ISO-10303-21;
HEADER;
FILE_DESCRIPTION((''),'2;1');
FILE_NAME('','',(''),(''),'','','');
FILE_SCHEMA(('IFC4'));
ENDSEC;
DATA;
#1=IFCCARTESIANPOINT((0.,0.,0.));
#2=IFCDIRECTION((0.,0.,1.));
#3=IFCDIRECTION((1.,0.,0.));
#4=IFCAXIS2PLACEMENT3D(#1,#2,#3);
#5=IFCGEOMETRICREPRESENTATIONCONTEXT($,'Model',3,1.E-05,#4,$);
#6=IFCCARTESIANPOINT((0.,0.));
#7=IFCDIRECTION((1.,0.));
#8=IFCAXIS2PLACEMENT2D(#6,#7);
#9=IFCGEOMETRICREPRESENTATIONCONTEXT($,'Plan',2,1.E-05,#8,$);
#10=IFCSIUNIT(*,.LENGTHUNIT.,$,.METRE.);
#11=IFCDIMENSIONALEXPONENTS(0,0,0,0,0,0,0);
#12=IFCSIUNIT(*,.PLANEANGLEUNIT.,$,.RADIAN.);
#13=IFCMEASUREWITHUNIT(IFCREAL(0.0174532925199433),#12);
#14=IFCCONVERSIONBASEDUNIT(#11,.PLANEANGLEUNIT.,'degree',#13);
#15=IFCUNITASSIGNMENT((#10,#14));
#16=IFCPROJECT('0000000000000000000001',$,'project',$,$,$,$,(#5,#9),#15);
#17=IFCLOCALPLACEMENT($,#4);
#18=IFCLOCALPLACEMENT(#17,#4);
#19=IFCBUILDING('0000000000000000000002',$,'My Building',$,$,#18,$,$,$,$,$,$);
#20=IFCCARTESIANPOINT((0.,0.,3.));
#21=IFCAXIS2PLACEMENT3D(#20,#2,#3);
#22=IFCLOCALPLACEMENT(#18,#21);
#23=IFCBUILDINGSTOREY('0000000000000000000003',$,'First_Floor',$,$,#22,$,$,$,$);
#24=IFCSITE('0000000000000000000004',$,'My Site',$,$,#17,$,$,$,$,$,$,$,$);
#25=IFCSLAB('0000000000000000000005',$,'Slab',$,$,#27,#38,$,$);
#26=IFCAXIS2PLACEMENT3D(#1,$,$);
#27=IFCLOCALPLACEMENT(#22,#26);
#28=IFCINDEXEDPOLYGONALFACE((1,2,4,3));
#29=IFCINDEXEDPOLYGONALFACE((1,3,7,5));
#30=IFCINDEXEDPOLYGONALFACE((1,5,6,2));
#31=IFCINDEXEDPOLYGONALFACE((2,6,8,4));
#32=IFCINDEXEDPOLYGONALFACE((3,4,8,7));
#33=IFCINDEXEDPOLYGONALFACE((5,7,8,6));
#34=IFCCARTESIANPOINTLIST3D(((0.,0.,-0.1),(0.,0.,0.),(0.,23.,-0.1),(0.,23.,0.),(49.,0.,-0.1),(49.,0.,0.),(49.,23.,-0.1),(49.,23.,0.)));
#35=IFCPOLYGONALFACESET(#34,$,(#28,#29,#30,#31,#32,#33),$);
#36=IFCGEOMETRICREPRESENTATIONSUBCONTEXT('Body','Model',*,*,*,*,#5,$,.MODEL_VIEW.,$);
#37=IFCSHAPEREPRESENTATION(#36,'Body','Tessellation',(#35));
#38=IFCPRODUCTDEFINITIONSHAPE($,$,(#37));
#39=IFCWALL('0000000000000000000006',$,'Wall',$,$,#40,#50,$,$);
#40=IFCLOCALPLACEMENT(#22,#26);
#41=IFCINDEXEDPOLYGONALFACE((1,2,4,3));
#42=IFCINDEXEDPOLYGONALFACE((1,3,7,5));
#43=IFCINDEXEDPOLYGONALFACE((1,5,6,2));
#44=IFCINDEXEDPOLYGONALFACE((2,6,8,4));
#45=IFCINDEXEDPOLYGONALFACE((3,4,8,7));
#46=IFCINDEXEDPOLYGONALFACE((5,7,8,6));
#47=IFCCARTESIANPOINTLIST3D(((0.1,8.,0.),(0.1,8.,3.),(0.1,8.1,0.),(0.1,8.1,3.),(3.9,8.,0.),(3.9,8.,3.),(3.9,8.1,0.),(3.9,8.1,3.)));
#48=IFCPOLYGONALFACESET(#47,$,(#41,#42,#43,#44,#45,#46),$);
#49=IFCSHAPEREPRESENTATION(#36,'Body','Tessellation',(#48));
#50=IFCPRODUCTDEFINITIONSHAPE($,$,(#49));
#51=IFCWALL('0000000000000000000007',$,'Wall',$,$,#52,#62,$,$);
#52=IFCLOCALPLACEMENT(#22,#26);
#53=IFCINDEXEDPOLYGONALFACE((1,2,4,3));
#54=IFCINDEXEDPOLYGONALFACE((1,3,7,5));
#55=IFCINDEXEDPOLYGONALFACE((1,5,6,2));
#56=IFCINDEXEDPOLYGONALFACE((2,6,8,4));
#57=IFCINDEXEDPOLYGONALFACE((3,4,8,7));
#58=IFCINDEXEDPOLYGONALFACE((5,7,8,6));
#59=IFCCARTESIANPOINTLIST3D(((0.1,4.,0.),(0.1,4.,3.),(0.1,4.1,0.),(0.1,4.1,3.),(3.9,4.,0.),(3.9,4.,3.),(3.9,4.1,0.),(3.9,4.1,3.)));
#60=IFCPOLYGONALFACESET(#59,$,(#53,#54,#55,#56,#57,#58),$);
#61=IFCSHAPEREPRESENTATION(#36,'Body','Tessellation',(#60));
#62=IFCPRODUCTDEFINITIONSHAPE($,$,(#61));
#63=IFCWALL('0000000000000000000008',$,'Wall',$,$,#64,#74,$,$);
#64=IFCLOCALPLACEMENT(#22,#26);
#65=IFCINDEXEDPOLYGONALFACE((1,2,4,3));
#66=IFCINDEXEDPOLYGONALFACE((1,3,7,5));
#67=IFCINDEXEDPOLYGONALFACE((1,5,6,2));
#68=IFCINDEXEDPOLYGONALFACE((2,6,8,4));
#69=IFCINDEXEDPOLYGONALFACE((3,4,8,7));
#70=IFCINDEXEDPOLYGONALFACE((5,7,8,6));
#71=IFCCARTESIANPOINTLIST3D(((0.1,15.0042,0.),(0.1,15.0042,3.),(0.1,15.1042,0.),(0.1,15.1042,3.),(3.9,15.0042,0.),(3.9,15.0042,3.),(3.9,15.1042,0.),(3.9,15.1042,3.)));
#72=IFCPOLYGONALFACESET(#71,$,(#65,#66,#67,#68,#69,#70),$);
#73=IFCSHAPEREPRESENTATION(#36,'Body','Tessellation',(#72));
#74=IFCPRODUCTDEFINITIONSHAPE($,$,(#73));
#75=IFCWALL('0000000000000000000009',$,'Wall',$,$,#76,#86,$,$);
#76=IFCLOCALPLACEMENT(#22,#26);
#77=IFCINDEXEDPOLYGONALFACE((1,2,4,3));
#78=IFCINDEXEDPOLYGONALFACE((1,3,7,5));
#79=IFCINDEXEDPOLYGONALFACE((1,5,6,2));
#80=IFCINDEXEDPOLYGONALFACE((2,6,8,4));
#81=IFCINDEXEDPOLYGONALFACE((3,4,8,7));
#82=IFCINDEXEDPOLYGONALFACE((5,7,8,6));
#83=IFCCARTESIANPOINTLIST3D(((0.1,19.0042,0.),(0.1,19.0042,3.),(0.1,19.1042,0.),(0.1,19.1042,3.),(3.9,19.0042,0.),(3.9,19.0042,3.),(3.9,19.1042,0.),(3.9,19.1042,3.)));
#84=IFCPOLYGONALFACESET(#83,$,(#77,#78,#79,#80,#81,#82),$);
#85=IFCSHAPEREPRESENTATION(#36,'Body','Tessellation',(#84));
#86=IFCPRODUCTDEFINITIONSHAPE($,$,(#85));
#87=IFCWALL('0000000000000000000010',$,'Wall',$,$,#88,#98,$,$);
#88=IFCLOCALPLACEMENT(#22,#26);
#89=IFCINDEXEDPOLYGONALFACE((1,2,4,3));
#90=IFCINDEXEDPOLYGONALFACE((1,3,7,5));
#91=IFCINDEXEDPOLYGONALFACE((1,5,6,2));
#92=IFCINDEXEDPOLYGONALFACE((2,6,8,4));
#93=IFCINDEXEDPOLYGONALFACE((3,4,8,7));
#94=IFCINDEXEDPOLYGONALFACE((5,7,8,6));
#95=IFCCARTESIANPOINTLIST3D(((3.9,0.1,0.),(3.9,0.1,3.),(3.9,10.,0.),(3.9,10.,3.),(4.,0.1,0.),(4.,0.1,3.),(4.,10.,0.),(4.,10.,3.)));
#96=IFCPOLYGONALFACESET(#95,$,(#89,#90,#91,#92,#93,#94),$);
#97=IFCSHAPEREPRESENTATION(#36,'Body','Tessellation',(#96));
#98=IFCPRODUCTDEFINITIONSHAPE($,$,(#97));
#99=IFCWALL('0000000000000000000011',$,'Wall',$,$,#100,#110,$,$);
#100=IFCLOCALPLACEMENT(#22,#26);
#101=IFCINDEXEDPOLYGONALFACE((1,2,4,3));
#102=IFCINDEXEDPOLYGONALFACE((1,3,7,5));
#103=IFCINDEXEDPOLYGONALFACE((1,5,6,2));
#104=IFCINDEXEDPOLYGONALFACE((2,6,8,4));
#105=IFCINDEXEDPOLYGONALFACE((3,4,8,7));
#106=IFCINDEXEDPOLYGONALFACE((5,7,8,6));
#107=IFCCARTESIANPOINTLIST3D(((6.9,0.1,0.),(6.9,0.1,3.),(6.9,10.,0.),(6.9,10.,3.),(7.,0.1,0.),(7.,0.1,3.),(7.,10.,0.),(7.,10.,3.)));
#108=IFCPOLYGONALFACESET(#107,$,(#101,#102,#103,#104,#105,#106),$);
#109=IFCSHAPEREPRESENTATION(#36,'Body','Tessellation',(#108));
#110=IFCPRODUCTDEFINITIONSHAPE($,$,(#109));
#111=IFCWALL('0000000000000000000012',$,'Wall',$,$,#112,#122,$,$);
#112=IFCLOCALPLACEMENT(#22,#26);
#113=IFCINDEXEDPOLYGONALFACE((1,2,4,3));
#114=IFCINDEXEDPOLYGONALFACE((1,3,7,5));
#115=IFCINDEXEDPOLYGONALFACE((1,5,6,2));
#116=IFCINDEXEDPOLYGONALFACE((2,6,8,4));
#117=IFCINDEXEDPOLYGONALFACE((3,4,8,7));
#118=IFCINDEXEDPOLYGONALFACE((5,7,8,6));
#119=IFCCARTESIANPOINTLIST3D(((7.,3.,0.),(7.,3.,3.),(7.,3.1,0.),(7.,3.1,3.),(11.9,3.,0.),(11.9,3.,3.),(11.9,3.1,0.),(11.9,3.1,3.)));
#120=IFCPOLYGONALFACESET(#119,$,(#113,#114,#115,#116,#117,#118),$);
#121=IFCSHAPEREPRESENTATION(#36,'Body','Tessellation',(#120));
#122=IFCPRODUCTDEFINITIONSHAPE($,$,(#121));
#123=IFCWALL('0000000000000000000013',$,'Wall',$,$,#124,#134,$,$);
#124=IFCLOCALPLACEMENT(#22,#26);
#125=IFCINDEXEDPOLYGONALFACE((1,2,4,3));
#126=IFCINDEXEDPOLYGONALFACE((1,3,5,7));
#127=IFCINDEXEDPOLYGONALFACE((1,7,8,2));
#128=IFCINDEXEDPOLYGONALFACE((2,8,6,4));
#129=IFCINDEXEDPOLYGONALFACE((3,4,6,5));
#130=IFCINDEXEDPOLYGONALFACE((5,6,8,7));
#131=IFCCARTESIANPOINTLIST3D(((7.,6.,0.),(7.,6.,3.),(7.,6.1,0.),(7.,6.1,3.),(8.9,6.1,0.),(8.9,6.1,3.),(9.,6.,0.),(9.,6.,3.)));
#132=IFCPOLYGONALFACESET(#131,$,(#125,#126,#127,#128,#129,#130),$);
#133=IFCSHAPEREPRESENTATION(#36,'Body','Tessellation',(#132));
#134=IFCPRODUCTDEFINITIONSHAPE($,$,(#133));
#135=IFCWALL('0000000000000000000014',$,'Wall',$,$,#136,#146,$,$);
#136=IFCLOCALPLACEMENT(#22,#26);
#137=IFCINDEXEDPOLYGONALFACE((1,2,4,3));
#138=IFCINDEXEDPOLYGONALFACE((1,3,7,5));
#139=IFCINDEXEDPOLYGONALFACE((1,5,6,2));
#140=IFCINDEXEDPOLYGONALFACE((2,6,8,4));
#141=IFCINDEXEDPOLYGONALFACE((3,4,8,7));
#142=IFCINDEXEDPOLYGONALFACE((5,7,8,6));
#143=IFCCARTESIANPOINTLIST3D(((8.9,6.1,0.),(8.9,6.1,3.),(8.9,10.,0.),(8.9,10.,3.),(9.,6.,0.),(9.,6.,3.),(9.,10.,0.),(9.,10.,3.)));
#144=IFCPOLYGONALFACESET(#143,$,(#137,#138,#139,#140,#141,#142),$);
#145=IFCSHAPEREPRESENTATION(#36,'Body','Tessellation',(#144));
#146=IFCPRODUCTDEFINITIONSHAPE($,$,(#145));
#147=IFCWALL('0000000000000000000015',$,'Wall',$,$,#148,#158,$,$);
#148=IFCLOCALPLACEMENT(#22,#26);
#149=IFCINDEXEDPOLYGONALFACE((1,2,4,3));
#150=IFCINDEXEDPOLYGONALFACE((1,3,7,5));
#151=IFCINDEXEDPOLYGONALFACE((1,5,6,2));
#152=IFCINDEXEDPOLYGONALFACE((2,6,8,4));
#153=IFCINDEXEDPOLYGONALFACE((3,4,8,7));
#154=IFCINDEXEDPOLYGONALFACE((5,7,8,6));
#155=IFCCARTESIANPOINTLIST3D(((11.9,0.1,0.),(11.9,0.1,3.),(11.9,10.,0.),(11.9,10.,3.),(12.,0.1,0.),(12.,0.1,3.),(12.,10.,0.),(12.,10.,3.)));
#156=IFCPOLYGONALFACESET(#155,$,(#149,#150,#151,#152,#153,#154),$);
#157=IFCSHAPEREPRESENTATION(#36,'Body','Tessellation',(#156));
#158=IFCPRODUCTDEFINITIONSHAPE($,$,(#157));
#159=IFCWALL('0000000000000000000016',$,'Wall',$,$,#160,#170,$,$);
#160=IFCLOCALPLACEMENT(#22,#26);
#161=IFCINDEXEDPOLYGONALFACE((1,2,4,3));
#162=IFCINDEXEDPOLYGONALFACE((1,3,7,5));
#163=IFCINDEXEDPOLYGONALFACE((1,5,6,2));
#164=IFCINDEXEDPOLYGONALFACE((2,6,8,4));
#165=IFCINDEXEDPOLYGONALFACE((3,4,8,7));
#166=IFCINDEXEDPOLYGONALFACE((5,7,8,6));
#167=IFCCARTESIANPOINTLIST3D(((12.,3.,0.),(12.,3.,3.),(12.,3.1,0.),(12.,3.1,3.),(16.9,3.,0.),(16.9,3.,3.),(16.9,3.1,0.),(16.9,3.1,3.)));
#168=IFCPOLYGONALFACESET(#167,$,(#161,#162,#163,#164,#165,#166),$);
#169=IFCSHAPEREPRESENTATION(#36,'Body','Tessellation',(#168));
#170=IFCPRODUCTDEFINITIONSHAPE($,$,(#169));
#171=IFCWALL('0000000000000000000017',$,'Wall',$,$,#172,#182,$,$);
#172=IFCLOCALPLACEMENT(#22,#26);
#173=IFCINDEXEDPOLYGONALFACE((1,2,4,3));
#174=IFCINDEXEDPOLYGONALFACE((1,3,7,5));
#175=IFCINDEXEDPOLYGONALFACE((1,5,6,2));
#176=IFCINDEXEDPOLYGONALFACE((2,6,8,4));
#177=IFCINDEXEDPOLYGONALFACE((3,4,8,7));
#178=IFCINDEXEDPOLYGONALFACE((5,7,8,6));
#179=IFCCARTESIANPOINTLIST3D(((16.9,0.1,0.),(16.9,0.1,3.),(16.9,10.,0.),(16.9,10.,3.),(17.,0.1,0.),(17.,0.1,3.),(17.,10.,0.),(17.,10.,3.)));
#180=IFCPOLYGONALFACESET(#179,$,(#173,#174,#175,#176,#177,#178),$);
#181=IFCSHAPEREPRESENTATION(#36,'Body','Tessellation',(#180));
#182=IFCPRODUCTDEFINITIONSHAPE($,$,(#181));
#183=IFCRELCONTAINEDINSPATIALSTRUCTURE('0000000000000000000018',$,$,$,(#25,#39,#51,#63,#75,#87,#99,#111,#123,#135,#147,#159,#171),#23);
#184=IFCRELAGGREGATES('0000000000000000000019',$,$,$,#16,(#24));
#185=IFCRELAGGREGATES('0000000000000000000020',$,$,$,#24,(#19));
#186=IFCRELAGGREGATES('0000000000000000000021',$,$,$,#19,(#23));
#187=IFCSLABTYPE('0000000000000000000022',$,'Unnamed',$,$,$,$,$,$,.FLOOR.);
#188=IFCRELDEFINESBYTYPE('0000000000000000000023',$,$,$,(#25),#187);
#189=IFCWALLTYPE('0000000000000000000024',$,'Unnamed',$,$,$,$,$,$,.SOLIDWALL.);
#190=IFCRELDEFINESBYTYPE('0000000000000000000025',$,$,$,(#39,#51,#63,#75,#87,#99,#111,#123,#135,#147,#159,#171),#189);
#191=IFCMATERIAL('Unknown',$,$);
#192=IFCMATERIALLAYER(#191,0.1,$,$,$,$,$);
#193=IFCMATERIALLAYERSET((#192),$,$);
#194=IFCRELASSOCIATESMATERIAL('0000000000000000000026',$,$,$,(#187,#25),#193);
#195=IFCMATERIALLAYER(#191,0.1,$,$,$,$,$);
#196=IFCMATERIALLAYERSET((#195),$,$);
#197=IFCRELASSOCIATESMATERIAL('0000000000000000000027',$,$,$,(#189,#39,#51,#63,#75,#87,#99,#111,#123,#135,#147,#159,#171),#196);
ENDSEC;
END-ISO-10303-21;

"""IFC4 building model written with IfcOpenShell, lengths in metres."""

from ifc_helpers import new_model, entity, si_unit, converted_unit, frame, origin_with_axes, origin_2d_with_axis, place, context, subcontext, project, spatial, line, indexed_curve, outline, extrude, material, layer, layer_set, layer_usage, type_object, element, save


model = new_model("IFC4")

# Units and contexts
model_context = context("Model", 3, precision=1e-05, world=origin_with_axes())
plan_context = context("Plan", 2, precision=1e-05, world=origin_2d_with_axis())
body_context = subcontext(model_context, "Body", "Model", "MODEL_VIEW")
ifc_project = project(units=[si_unit("LENGTHUNIT", "METRE"), converted_unit("PLANEANGLEUNIT", "degree", entity("IfcReal", 0.0174532925199433), si_unit("PLANEANGLEUNIT", "RADIAN"), dimensions=[0, 0, 0, 0, 0, 0, 0])], contexts=[model_context, plan_context])

# Site, building, storey
site_placement = place(None, origin_with_axes())
site = spatial("IfcSite", under=ifc_project, at=site_placement, Name="My Site")
building_placement = place(site_placement, origin_with_axes())
building = spatial("IfcBuilding", under=site, at=building_placement, Name="My Building")
storey_placement = place(building_placement, frame((0.0, 0.0, 3.0), z_axis=(0.0, 0.0, 1.0), x_axis=(1.0, 0.0, 0.0)))
storey = spatial("IfcBuildingStorey", under=building, at=storey_placement, Name="First_Floor")

# Slab
ifc_material = material(Name="Unknown")
ifc_layer_1 = layer(ifc_material, 0.1)
ifc_layer_set_1 = layer_set([ifc_layer_1])
ifc_layer_usage_1 = layer_usage(ifc_layer_set_1, "AXIS3", "POSITIVE", -0.1)
slab_type = type_object("IfcSlabType", Name="Unnamed", PredefinedType="FLOOR", material=ifc_layer_set_1)
slab_placement = place(storey_placement, frame((0.0, 23.0, 0.0), z_axis=(0.0, 0.0, 1.0), x_axis=(1.0, 0.0, 0.0)))
element("IfcSlab", 1, at=slab_placement, inside=storey, type_object=slab_type, material=ifc_layer_usage_1, Name="Slab", context=body_context, shape_type="SweptSolid", body=[
    extrude(outline(indexed_curve([(0.0, 0.0), (0.0, -23.0), (49.0, -23.0), (49.0, 0.0), (0.0, 0.0)])), frame((0.0, 0.0, -0.1), z_axis=(0.0, 0.0, 1.0), x_axis=(1.0, 0.0, 0.0)), (0.0, 0.0, 1.0), 0.1),
])

# Walls
ifc_layer_2 = layer(ifc_material, 0.1)
ifc_layer_set_2 = layer_set([ifc_layer_2])
ifc_layer_usage_2 = layer_usage(ifc_layer_set_2, "AXIS2", "POSITIVE", 0.0)
wall_type = type_object("IfcWallType", Name="Unnamed", PredefinedType="SOLIDWALL", material=ifc_layer_set_2)
wall_1_placement = place(storey_placement, frame((0.1, 8.0, 0.0), z_axis=(0.0, 0.0, 1.0), x_axis=(1.0, 0.0, 0.0)))
element("IfcWall", 2, at=wall_1_placement, inside=storey, type_object=wall_type, material=ifc_layer_usage_2, Name="Wall", context=body_context, shape_type="SweptSolid", body=[
    extrude(outline(indexed_curve([(0.0, 0.0), (0.0, 0.1), (3.8, 0.1), (3.8, 0.0)], segments=[line(1, 2, 3, 4, 1)])), origin_with_axes(), (0.0, 0.0, 1.0), 3.0),
])
ifc_layer_usage_3 = layer_usage(ifc_layer_set_2, "AXIS2", "POSITIVE", 0.0)
wall_2_placement = place(storey_placement, frame((0.1, 4.0, 0.0), z_axis=(0.0, 0.0, 1.0), x_axis=(1.0, 0.0, 0.0)))
element("IfcWall", 3, at=wall_2_placement, inside=storey, type_object=wall_type, material=ifc_layer_usage_3, Name="Wall", context=body_context, shape_type="SweptSolid", body=[
    extrude(outline(indexed_curve([(0.0, 0.0), (0.0, 0.1), (3.8, 0.1), (3.8, 0.0)], segments=[line(1, 2, 3, 4, 1)])), origin_with_axes(), (0.0, 0.0, 1.0), 3.0),
])
ifc_layer_usage_4 = layer_usage(ifc_layer_set_2, "AXIS2", "POSITIVE", 0.0)
wall_3_placement = place(storey_placement, frame((0.1, 15.0042, 0.0), z_axis=(0.0, 0.0, 1.0), x_axis=(1.0, 0.0, 0.0)))
element("IfcWall", 4, at=wall_3_placement, inside=storey, type_object=wall_type, material=ifc_layer_usage_4, Name="Wall", context=body_context, shape_type="SweptSolid", body=[
    extrude(outline(indexed_curve([(0.0, 0.0), (0.0, 0.1), (3.8, 0.1), (3.8, 0.0)], segments=[line(1, 2, 3, 4, 1)])), origin_with_axes(), (0.0, 0.0, 1.0), 3.0),
])
ifc_layer_usage_5 = layer_usage(ifc_layer_set_2, "AXIS2", "POSITIVE", 0.0)
wall_4_placement = place(storey_placement, frame((0.1, 19.0042, 0.0), z_axis=(0.0, 0.0, 1.0), x_axis=(1.0, 0.0, 0.0)))
element("IfcWall", 5, at=wall_4_placement, inside=storey, type_object=wall_type, material=ifc_layer_usage_5, Name="Wall", context=body_context, shape_type="SweptSolid", body=[
    extrude(outline(indexed_curve([(0.0, 0.0), (0.0, 0.1), (3.8, 0.1), (3.8, 0.0)], segments=[line(1, 2, 3, 4, 1)])), origin_with_axes(), (0.0, 0.0, 1.0), 3.0),
])
ifc_layer_usage_6 = layer_usage(ifc_layer_set_2, "AXIS2", "POSITIVE", 0.0)
wall_5_placement = place(storey_placement, frame((3.9, 10.0, 0.0), z_axis=(0.0, 0.0, 1.0), x_axis=(0.0, -1.0, 0.0)))
element("IfcWall", 6, at=wall_5_placement, inside=storey, type_object=wall_type, material=ifc_layer_usage_6, Name="Wall", context=body_context, shape_type="SweptSolid", body=[
    extrude(outline(indexed_curve([(0.0, 0.0), (0.0, 0.1), (9.9, 0.1), (9.9, 0.0)], segments=[line(1, 2, 3, 4, 1)])), origin_with_axes(), (0.0, 0.0, 1.0), 3.0),
])
ifc_layer_usage_7 = layer_usage(ifc_layer_set_2, "AXIS2", "POSITIVE", 0.0)
wall_6_placement = place(storey_placement, frame((6.9, 10.0, 0.0), z_axis=(0.0, 0.0, 1.0), x_axis=(0.0, -1.0, 0.0)))
element("IfcWall", 7, at=wall_6_placement, inside=storey, type_object=wall_type, material=ifc_layer_usage_7, Name="Wall", context=body_context, shape_type="SweptSolid", body=[
    extrude(outline(indexed_curve([(0.0, 0.0), (0.0, 0.1), (9.9, 0.1), (9.9, 0.0)], segments=[line(1, 2, 3, 4, 1)])), origin_with_axes(), (0.0, 0.0, 1.0), 3.0),
])
ifc_layer_usage_8 = layer_usage(ifc_layer_set_2, "AXIS2", "POSITIVE", 0.0)
wall_7_placement = place(storey_placement, frame((7.0, 3.0, 0.0), z_axis=(0.0, 0.0, 1.0), x_axis=(1.0, 0.0, 0.0)))
element("IfcWall", 8, at=wall_7_placement, inside=storey, type_object=wall_type, material=ifc_layer_usage_8, Name="Wall", context=body_context, shape_type="SweptSolid", body=[
    extrude(outline(indexed_curve([(0.0, 0.0), (0.0, 0.1), (4.9, 0.1), (4.9, 0.0)], segments=[line(1, 2, 3, 4, 1)])), origin_with_axes(), (0.0, 0.0, 1.0), 3.0),
])
ifc_layer_usage_9 = layer_usage(ifc_layer_set_2, "AXIS2", "POSITIVE", 0.0)
wall_8_placement = place(storey_placement, frame((7.0, 6.0, 0.0), z_axis=(0.0, 0.0, 1.0), x_axis=(1.0, 0.0, 0.0)))
element("IfcWall", 9, at=wall_8_placement, inside=storey, type_object=wall_type, material=ifc_layer_usage_9, Name="Wall", context=body_context, shape_type="SweptSolid", body=[
    extrude(outline(indexed_curve([(0.0, 0.0), (0.0, 0.1), (1.9, 0.1), (2.0, 0.0)], segments=[line(1, 2, 3, 4, 1)])), origin_with_axes(), (0.0, 0.0, 1.0), 3.0),
])
ifc_layer_usage_10 = layer_usage(ifc_layer_set_2, "AXIS2", "POSITIVE", 0.0)
wall_9_placement = place(storey_placement, frame((9.0, 6.0, 0.0), z_axis=(0.0, 0.0, 1.0), x_axis=(0.0, 1.0, 0.0)))
element("IfcWall", 10, at=wall_9_placement, inside=storey, type_object=wall_type, material=ifc_layer_usage_10, Name="Wall", context=body_context, shape_type="SweptSolid", body=[
    extrude(outline(indexed_curve([(0.0, 0.0), (0.1, 0.1), (4.0, 0.1), (4.0, 0.0)], segments=[line(1, 2, 3, 4, 1)])), origin_with_axes(), (0.0, 0.0, 1.0), 3.0),
])
ifc_layer_usage_11 = layer_usage(ifc_layer_set_2, "AXIS2", "POSITIVE", 0.0)
wall_10_placement = place(storey_placement, frame((11.9, 10.0, 0.0), z_axis=(0.0, 0.0, 1.0), x_axis=(0.0, -1.0, 0.0)))
element("IfcWall", 11, at=wall_10_placement, inside=storey, type_object=wall_type, material=ifc_layer_usage_11, Name="Wall", context=body_context, shape_type="SweptSolid", body=[
    extrude(outline(indexed_curve([(0.0, 0.0), (0.0, 0.1), (9.9, 0.1), (9.9, 0.0)], segments=[line(1, 2, 3, 4, 1)])), origin_with_axes(), (0.0, 0.0, 1.0), 3.0),
])
ifc_layer_usage_12 = layer_usage(ifc_layer_set_2, "AXIS2", "POSITIVE", 0.0)
wall_11_placement = place(storey_placement, frame((12.0, 3.0, 0.0), z_axis=(0.0, 0.0, 1.0), x_axis=(1.0, 0.0, 0.0)))
element("IfcWall", 12, at=wall_11_placement, inside=storey, type_object=wall_type, material=ifc_layer_usage_12, Name="Wall", context=body_context, shape_type="SweptSolid", body=[
    extrude(outline(indexed_curve([(0.0, 0.0), (0.0, 0.1), (4.9, 0.1), (4.9, 0.0)], segments=[line(1, 2, 3, 4, 1)])), origin_with_axes(), (0.0, 0.0, 1.0), 3.0),
])
ifc_layer_usage_13 = layer_usage(ifc_layer_set_2, "AXIS2", "POSITIVE", 0.0)
wall_12_placement = place(storey_placement, frame((16.9, 10.0, 0.0), z_axis=(0.0, 0.0, 1.0), x_axis=(0.0, -1.0, 0.0)))
element("IfcWall", 13, at=wall_12_placement, inside=storey, type_object=wall_type, material=ifc_layer_usage_13, Name="Wall", context=body_context, shape_type="SweptSolid", body=[
    extrude(outline(indexed_curve([(0.0, 0.0), (0.0, 0.1), (9.9, 0.1), (9.9, 0.0)], segments=[line(1, 2, 3, 4, 1)])), origin_with_axes(), (0.0, 0.0, 1.0), 3.0),
])

save(model, "model.ifc")
